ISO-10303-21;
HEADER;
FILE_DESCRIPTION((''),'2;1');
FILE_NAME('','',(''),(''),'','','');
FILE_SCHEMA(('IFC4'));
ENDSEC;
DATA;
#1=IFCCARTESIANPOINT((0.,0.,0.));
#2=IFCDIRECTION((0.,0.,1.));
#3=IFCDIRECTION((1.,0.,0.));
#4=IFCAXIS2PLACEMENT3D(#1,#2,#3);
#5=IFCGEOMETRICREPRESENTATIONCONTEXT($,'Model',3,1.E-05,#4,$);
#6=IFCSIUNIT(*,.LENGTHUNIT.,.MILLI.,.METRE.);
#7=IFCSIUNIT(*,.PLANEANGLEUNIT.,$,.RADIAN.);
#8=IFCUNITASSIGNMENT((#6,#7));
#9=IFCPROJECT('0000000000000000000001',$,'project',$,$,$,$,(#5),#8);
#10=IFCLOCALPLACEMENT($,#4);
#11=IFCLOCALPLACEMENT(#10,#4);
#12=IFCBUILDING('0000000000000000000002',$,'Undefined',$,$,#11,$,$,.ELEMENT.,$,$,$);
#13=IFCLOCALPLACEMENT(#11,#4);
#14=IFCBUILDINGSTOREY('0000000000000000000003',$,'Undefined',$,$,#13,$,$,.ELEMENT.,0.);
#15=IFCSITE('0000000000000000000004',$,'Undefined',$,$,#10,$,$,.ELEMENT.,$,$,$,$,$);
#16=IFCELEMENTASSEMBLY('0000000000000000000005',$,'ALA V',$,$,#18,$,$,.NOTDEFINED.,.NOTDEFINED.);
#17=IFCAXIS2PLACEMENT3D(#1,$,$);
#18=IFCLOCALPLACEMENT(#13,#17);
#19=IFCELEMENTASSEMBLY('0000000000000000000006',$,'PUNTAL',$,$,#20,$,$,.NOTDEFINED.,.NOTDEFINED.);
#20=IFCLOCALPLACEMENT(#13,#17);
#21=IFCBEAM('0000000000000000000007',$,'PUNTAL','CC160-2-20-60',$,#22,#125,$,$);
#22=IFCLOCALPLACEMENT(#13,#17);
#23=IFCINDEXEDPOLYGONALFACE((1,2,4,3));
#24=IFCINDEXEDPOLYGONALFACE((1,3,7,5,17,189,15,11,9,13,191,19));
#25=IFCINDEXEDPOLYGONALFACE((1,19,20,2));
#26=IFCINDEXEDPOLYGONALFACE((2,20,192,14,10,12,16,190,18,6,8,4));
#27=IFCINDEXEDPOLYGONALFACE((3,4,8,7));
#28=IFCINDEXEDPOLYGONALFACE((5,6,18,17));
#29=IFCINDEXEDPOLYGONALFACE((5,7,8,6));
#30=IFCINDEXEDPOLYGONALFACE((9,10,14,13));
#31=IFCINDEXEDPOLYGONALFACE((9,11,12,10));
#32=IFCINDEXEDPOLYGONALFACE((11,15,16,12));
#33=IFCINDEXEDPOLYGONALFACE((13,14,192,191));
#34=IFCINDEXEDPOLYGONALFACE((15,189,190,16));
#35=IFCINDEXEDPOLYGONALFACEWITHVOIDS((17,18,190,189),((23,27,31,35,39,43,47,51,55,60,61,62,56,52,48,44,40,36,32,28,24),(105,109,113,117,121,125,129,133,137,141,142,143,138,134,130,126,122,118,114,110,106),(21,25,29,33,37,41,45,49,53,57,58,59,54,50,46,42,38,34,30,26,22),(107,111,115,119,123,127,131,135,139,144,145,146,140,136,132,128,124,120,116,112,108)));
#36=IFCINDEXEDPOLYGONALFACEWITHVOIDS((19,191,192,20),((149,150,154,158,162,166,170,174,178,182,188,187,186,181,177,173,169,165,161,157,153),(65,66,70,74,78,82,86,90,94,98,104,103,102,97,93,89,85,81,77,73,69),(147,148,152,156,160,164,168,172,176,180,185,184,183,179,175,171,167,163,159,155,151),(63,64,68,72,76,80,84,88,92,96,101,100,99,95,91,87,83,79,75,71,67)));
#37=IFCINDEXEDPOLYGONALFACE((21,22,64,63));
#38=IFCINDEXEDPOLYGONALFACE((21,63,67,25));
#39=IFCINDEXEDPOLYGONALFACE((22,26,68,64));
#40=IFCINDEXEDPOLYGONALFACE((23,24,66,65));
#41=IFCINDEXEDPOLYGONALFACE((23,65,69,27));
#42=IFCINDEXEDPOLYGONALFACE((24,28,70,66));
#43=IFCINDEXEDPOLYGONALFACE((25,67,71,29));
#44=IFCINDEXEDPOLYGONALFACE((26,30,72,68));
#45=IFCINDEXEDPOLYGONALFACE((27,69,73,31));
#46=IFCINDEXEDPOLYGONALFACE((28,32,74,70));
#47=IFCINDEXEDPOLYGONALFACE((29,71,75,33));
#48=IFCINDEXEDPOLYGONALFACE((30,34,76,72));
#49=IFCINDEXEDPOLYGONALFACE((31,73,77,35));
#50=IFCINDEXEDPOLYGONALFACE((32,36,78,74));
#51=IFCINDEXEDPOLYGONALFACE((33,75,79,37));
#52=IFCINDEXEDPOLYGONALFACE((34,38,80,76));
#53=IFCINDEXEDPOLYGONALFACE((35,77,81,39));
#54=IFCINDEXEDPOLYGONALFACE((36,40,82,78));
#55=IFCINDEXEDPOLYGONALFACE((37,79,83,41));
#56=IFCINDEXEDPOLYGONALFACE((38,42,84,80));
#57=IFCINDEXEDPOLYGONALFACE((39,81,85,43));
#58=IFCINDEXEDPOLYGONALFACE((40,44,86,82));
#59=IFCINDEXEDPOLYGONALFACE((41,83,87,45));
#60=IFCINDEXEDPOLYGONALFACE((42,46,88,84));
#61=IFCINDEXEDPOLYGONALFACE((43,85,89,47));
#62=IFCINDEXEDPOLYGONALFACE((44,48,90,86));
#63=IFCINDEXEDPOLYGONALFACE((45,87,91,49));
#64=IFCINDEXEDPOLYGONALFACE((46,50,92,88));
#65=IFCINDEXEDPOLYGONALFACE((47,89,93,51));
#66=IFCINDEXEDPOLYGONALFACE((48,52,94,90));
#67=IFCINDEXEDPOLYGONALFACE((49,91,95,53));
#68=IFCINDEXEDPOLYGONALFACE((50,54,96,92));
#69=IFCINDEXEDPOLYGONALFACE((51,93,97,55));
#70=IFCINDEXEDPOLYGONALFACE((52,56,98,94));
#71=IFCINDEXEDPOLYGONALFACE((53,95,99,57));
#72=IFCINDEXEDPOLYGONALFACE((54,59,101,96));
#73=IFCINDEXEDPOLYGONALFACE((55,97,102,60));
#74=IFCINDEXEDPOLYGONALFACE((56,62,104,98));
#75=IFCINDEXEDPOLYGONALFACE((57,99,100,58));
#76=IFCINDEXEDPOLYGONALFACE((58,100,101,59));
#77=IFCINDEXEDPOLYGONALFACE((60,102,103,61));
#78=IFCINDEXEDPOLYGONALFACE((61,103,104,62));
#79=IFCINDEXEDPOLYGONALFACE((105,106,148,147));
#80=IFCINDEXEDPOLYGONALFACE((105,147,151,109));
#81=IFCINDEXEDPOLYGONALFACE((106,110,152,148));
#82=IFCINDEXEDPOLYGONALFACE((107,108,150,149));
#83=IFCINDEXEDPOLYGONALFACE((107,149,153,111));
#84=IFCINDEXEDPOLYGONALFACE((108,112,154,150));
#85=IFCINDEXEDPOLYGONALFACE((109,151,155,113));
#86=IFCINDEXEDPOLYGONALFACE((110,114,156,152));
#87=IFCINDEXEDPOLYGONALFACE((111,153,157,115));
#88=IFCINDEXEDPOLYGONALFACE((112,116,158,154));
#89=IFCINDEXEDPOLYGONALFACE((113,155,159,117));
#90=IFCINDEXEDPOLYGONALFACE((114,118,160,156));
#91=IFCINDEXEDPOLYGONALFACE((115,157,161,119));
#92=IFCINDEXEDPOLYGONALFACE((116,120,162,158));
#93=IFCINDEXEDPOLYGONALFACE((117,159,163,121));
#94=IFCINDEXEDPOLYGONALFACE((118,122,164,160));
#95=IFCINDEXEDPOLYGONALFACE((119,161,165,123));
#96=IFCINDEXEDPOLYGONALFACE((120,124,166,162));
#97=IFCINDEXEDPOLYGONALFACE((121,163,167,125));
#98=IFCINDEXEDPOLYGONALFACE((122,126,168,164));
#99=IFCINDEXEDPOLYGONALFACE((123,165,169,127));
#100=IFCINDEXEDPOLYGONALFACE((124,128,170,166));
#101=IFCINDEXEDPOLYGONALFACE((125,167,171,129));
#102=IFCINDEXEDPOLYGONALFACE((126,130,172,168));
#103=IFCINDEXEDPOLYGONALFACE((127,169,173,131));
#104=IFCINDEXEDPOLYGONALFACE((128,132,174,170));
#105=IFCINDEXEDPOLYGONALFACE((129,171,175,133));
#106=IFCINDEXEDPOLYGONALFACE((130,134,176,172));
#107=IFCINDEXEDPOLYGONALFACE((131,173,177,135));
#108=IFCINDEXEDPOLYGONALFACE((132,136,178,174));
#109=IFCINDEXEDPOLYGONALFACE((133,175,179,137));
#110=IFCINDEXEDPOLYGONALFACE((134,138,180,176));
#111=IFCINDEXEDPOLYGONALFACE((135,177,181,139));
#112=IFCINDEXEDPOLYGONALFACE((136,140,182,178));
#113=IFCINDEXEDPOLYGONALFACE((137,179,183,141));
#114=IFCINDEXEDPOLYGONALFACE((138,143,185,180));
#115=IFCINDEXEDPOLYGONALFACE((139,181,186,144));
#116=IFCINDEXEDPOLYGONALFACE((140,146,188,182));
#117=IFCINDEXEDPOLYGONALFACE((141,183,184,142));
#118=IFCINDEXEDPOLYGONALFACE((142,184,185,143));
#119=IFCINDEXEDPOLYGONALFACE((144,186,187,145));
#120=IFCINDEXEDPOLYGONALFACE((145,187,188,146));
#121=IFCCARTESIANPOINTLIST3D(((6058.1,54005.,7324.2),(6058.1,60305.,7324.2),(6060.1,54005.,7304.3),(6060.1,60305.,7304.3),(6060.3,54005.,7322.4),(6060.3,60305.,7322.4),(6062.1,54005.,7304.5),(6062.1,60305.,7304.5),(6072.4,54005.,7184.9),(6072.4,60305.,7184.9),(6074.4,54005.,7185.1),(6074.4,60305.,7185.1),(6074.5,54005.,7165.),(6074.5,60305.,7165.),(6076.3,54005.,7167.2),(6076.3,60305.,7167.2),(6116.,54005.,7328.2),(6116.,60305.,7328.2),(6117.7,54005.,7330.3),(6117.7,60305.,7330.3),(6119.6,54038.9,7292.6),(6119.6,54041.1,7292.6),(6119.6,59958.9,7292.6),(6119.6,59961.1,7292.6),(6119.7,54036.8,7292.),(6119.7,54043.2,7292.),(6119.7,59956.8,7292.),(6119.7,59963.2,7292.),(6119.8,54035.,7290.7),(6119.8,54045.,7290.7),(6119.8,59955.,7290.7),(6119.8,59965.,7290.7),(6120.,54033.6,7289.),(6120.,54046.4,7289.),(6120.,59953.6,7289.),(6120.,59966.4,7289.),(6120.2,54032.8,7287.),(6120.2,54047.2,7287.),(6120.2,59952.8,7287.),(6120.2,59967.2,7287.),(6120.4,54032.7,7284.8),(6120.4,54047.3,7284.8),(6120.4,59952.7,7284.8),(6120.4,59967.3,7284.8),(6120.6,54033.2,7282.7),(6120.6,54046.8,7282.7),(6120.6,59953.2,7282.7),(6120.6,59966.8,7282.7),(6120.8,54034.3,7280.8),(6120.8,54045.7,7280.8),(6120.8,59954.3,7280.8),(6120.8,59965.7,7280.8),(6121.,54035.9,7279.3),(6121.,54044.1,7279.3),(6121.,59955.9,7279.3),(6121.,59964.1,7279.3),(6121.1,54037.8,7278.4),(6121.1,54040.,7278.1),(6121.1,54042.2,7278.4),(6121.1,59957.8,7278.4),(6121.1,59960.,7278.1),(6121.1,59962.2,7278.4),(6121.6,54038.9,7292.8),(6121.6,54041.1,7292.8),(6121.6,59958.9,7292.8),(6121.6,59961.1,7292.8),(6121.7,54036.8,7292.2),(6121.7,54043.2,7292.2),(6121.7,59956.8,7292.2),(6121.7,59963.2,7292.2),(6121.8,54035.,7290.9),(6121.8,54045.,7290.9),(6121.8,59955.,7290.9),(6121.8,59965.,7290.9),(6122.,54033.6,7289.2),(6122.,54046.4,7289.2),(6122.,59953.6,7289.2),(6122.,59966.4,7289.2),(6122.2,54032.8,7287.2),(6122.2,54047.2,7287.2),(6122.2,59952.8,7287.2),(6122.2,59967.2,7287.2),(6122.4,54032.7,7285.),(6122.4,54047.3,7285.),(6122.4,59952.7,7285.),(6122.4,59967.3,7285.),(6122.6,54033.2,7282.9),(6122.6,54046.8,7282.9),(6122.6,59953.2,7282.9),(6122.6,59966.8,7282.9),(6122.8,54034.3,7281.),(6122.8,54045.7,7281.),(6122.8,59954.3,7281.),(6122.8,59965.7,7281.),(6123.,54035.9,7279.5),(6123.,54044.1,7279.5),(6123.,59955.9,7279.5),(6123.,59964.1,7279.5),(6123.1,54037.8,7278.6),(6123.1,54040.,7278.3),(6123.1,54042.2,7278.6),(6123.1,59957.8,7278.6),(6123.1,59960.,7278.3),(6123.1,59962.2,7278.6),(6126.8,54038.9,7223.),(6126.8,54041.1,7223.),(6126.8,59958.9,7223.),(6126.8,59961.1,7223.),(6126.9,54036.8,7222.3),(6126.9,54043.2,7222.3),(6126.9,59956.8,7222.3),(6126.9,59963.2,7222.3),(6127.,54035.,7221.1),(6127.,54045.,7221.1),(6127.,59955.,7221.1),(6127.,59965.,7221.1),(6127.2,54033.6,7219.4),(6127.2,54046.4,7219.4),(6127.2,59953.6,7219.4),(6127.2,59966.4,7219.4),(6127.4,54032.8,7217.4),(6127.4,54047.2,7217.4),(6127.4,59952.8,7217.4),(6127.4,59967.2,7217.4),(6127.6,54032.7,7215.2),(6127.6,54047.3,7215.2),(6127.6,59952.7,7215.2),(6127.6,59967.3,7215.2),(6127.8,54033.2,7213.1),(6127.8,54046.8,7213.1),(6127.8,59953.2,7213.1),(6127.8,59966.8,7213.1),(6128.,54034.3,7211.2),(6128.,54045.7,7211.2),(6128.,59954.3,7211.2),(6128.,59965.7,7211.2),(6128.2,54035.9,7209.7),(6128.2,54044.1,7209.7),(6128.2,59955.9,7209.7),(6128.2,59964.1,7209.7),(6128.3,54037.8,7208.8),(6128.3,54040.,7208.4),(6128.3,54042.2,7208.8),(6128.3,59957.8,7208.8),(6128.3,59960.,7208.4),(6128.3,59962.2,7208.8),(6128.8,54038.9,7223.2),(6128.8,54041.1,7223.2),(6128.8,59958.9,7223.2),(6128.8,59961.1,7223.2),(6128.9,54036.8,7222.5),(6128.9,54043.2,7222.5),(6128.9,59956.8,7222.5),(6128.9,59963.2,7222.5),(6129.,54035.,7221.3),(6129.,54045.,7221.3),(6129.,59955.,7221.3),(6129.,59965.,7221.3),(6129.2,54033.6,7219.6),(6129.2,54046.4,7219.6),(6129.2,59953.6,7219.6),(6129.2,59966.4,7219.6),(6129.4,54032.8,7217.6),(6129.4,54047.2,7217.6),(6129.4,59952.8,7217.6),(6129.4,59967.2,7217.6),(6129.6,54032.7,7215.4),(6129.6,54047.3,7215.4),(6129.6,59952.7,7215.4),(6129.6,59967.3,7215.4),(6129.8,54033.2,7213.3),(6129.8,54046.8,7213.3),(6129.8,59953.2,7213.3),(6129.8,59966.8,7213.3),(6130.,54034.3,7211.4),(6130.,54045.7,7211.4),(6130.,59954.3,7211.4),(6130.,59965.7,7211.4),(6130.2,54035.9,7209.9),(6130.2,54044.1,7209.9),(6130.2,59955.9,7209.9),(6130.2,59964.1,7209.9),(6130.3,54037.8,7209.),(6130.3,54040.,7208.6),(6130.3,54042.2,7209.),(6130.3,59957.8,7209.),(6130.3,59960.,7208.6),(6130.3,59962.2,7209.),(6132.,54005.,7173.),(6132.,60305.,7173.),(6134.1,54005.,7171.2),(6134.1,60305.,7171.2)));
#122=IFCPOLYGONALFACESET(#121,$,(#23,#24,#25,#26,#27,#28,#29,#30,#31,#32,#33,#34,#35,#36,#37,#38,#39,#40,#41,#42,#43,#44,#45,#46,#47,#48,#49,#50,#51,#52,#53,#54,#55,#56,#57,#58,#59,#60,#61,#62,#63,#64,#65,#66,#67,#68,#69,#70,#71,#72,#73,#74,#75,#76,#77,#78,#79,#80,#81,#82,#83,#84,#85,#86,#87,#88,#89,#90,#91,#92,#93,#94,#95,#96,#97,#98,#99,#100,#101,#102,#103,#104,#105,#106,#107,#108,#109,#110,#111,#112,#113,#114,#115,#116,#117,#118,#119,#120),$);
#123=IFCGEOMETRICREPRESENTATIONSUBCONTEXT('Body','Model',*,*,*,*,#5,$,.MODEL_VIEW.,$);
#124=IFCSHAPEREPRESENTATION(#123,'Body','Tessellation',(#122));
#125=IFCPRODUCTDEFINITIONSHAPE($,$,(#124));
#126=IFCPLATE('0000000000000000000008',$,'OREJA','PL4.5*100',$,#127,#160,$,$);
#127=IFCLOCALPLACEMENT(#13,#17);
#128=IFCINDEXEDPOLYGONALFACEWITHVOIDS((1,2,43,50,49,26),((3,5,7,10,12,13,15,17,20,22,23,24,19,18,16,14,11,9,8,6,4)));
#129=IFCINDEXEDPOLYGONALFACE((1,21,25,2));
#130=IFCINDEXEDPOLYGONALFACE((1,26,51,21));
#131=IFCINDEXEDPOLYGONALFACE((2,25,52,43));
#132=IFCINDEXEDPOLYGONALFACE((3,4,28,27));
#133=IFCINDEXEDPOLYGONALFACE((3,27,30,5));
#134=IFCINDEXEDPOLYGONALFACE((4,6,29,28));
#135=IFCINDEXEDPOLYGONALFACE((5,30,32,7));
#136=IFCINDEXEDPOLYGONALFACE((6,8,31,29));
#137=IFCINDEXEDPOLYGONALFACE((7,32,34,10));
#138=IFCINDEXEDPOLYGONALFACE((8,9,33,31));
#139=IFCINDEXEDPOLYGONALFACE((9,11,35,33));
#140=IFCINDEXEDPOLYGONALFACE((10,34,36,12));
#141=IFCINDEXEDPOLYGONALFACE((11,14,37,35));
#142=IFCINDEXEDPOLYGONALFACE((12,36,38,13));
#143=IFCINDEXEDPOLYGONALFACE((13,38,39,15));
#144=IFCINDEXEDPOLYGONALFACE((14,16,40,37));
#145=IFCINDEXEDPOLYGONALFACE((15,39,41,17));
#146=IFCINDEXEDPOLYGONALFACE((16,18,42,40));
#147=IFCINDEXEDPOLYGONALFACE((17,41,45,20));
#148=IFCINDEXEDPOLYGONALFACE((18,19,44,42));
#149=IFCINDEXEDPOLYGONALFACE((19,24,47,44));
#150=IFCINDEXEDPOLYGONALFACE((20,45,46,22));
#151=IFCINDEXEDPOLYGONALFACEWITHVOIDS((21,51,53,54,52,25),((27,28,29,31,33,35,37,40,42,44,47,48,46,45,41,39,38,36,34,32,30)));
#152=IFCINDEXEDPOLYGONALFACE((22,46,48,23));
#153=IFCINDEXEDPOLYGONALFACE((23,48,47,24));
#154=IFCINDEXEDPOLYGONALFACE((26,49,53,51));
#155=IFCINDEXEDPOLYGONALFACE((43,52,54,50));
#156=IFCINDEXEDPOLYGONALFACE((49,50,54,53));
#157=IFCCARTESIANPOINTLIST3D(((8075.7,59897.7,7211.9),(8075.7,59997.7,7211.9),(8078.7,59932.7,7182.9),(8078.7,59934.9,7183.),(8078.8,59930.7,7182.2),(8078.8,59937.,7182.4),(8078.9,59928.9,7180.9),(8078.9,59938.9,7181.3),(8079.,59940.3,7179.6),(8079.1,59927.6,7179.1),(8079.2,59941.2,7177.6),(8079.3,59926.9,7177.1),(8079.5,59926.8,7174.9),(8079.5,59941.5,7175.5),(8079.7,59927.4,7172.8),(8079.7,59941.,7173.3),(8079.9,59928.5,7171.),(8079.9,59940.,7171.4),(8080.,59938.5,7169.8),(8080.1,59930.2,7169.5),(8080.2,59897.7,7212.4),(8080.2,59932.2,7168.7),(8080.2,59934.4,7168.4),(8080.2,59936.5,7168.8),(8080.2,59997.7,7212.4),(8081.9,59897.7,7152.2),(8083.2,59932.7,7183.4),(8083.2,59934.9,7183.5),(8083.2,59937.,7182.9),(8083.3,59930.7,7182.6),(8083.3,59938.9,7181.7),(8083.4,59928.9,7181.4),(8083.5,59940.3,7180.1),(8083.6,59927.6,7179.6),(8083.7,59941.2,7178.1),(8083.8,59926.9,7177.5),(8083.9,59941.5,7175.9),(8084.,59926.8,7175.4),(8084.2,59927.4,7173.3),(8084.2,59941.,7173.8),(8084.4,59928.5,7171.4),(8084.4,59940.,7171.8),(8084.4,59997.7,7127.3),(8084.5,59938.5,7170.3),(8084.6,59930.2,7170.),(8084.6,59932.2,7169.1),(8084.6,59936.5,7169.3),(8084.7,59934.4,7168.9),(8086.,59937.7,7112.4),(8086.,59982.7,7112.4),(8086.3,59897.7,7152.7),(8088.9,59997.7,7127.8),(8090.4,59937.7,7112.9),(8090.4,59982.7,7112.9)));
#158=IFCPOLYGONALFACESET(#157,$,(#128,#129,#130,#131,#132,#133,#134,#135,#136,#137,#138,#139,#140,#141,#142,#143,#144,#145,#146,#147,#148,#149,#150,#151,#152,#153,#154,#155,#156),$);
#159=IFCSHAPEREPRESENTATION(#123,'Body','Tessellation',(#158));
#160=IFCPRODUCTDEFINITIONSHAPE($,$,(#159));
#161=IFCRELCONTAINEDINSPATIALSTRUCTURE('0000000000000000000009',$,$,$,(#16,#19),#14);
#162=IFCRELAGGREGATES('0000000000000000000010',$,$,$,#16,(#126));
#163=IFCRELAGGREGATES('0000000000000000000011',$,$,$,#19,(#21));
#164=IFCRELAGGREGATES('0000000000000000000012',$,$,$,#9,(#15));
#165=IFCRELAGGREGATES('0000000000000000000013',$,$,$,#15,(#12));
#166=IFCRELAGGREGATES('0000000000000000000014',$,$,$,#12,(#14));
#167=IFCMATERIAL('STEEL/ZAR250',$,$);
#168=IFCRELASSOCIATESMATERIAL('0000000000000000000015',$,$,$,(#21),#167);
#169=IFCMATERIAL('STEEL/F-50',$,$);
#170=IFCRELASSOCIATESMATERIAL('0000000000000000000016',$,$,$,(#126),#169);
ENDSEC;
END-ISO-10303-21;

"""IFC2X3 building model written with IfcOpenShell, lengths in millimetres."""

from ifc_helpers import new_model, si_unit, frame, origin_with_axes, origin_2d_with_axis, place, context, subcontext, project, spatial, polyline, circle, c_section, outline, extrude, source, transform, mapped, material, element, aggregate, save


model = new_model("IFC2X3")

# Units and contexts
model_context = context("Model", 3, precision=1e-05, world=origin_with_axes())
body_context = subcontext(model_context, "Body", "Model", "MODEL_VIEW")
ifc_project = project(units=[si_unit("LENGTHUNIT", "METRE", prefix="MILLI"), si_unit("PLANEANGLEUNIT", "RADIAN")], contexts=[model_context])

# Site, building, storey
site_placement = place(None, origin_with_axes())
site = spatial("IfcSite", under=ifc_project, at=site_placement, Name="Undefined", CompositionType="ELEMENT")
building_placement = place(site_placement, origin_with_axes())
building = spatial("IfcBuilding", under=site, at=building_placement, Name="Undefined", CompositionType="ELEMENT")
storey_placement = place(building_placement, origin_with_axes())
storey = spatial("IfcBuildingStorey", under=building, at=storey_placement, Name="Undefined", CompositionType="ELEMENT", Elevation=0.0)

# Element assembly
assembly_1_placement = place(storey_placement, origin_with_axes())
assembly_1 = element("IfcElementAssembly", 1, at=assembly_1_placement, inside=storey, Name="ALA V", AssemblyPlace="NOTDEFINED", PredefinedType="NOTDEFINED")
ifc_material_1 = material(Name="STEEL/F-50")

# Shared definitions
ifc_material_2 = material(Name="STEEL/ZAR250")

# Element assembly, beam, openings
assembly_2_placement = place(storey_placement, origin_with_axes())
assembly_2 = element("IfcElementAssembly", 2, at=assembly_2_placement, inside=storey, Name="PUNTAL", AssemblyPlace="NOTDEFINED", PredefinedType="NOTDEFINED")
beam_1_placement = place(assembly_2_placement, frame((6096.1, 60305.0, 7247.7), z_axis=(-0.102562, 0.0, 0.994727), x_axis=(0.0, -1.0, 0.0)))
beam_1 = element("IfcBeam", 3, at=beam_1_placement, material=ifc_material_2, Name="PUNTAL", Description="CC160-2-20-60", context=body_context, shape_type="SweptSolid", body=[
    extrude(c_section(Depth=160.0, Width=60.0, WallThickness=2.0, Girth=20.0, at=origin_2d_with_axis()), frame((6300.0, 0.0, 0.0), z_axis=(-1.0, 0.0, 0.0), x_axis=(0.0, -1.0, 0.0)), (0.0, 0.0, 1.0), 6300.0),
])
shared_shape_1 = source(origin_with_axes(), body_context, "Body", "SweptSolid", [
    extrude(circle(Radius=7.3, at=origin_2d_with_axis()), frame((0.0, -0.1, 0.0), z_axis=(0.0, 1.0, 0.0), x_axis=(1.0, 0.0, 0.0)), (0.0, 0.0, 1.0), 2.2),
])
opening_1_placement = place(assembly_2_placement, frame((6122.4, 59960.0, 7285.6), z_axis=(0.0, 1.0, 0.0), x_axis=(0.102562, 0.0, -0.994727)))
element("IfcOpeningElement", 4, at=opening_1_placement, cuts=beam_1, ObjectType="Opening", context=body_context, shape_type="MappedRepresentation", body=[
    mapped(shared_shape_1, transform((0.0, 0.0, 0.0))),
    mapped(shared_shape_1, transform((70.0, 0.0, 0.0))),
])
opening_2_placement = place(assembly_2_placement, frame((6122.4, 54040.0, 7285.6), z_axis=(0.0, 1.0, 0.0), x_axis=(0.102562, 0.0, -0.994727)))
element("IfcOpeningElement", 5, at=opening_2_placement, cuts=beam_1, ObjectType="Opening", context=body_context, shape_type="MappedRepresentation", body=[
    mapped(shared_shape_1, transform((0.0, 0.0, 0.0))),
    mapped(shared_shape_1, transform((70.0, 0.0, 0.0))),
])

# Plate, opening
plate_1_placement = place(assembly_1_placement, frame((8088.2, 59997.7, 7112.7), z_axis=(-0.994727, 0.0, -0.102562), x_axis=(0.0, -1.0, 0.0)))
plate_1 = element("IfcPlate", 6, at=plate_1_placement, material=ifc_material_1, Name="OREJA", Description="PL4.5*100", context=body_context, shape_type="SweptSolid", body=[
    extrude(outline(polyline([(0.0, 15.0), (15.0, 0.0), (60.0, 0.0), (100.0, 40.0), (100.0, 100.0), (0.0, 100.0), (0.0, 15.0)])), frame((0.0, 0.0, -2.2), z_axis=(0.0, 0.0, 1.0), x_axis=(1.0, 0.0, 0.0)), (0.0, 0.0, 1.0), 4.5),
])
shared_shape_2 = source(origin_with_axes(), body_context, "Body", "SweptSolid", [
    extrude(circle(Radius=7.3, at=origin_2d_with_axis()), frame((0.0, -0.1, 0.0), z_axis=(0.0, 1.0, 0.0), x_axis=(1.0, 0.0, 0.0)), (0.0, 0.0, 1.0), 4.7),
])
opening_3_placement = place(assembly_1_placement, frame((8083.9, 59934.1, 7176.2), z_axis=(0.072522, -0.707107, -0.703378), x_axis=(-0.072522, -0.707107, 0.703378)))
element("IfcOpeningElement", 7, at=opening_3_placement, cuts=plate_1, ObjectType="Opening", context=body_context, shape_type="MappedRepresentation", body=[
    mapped(shared_shape_2, transform((0.0, 0.0, 0.0))),
])

aggregate(assembly_1, [plate_1])
aggregate(assembly_2, [beam_1])

save(model, "model.ifc")
